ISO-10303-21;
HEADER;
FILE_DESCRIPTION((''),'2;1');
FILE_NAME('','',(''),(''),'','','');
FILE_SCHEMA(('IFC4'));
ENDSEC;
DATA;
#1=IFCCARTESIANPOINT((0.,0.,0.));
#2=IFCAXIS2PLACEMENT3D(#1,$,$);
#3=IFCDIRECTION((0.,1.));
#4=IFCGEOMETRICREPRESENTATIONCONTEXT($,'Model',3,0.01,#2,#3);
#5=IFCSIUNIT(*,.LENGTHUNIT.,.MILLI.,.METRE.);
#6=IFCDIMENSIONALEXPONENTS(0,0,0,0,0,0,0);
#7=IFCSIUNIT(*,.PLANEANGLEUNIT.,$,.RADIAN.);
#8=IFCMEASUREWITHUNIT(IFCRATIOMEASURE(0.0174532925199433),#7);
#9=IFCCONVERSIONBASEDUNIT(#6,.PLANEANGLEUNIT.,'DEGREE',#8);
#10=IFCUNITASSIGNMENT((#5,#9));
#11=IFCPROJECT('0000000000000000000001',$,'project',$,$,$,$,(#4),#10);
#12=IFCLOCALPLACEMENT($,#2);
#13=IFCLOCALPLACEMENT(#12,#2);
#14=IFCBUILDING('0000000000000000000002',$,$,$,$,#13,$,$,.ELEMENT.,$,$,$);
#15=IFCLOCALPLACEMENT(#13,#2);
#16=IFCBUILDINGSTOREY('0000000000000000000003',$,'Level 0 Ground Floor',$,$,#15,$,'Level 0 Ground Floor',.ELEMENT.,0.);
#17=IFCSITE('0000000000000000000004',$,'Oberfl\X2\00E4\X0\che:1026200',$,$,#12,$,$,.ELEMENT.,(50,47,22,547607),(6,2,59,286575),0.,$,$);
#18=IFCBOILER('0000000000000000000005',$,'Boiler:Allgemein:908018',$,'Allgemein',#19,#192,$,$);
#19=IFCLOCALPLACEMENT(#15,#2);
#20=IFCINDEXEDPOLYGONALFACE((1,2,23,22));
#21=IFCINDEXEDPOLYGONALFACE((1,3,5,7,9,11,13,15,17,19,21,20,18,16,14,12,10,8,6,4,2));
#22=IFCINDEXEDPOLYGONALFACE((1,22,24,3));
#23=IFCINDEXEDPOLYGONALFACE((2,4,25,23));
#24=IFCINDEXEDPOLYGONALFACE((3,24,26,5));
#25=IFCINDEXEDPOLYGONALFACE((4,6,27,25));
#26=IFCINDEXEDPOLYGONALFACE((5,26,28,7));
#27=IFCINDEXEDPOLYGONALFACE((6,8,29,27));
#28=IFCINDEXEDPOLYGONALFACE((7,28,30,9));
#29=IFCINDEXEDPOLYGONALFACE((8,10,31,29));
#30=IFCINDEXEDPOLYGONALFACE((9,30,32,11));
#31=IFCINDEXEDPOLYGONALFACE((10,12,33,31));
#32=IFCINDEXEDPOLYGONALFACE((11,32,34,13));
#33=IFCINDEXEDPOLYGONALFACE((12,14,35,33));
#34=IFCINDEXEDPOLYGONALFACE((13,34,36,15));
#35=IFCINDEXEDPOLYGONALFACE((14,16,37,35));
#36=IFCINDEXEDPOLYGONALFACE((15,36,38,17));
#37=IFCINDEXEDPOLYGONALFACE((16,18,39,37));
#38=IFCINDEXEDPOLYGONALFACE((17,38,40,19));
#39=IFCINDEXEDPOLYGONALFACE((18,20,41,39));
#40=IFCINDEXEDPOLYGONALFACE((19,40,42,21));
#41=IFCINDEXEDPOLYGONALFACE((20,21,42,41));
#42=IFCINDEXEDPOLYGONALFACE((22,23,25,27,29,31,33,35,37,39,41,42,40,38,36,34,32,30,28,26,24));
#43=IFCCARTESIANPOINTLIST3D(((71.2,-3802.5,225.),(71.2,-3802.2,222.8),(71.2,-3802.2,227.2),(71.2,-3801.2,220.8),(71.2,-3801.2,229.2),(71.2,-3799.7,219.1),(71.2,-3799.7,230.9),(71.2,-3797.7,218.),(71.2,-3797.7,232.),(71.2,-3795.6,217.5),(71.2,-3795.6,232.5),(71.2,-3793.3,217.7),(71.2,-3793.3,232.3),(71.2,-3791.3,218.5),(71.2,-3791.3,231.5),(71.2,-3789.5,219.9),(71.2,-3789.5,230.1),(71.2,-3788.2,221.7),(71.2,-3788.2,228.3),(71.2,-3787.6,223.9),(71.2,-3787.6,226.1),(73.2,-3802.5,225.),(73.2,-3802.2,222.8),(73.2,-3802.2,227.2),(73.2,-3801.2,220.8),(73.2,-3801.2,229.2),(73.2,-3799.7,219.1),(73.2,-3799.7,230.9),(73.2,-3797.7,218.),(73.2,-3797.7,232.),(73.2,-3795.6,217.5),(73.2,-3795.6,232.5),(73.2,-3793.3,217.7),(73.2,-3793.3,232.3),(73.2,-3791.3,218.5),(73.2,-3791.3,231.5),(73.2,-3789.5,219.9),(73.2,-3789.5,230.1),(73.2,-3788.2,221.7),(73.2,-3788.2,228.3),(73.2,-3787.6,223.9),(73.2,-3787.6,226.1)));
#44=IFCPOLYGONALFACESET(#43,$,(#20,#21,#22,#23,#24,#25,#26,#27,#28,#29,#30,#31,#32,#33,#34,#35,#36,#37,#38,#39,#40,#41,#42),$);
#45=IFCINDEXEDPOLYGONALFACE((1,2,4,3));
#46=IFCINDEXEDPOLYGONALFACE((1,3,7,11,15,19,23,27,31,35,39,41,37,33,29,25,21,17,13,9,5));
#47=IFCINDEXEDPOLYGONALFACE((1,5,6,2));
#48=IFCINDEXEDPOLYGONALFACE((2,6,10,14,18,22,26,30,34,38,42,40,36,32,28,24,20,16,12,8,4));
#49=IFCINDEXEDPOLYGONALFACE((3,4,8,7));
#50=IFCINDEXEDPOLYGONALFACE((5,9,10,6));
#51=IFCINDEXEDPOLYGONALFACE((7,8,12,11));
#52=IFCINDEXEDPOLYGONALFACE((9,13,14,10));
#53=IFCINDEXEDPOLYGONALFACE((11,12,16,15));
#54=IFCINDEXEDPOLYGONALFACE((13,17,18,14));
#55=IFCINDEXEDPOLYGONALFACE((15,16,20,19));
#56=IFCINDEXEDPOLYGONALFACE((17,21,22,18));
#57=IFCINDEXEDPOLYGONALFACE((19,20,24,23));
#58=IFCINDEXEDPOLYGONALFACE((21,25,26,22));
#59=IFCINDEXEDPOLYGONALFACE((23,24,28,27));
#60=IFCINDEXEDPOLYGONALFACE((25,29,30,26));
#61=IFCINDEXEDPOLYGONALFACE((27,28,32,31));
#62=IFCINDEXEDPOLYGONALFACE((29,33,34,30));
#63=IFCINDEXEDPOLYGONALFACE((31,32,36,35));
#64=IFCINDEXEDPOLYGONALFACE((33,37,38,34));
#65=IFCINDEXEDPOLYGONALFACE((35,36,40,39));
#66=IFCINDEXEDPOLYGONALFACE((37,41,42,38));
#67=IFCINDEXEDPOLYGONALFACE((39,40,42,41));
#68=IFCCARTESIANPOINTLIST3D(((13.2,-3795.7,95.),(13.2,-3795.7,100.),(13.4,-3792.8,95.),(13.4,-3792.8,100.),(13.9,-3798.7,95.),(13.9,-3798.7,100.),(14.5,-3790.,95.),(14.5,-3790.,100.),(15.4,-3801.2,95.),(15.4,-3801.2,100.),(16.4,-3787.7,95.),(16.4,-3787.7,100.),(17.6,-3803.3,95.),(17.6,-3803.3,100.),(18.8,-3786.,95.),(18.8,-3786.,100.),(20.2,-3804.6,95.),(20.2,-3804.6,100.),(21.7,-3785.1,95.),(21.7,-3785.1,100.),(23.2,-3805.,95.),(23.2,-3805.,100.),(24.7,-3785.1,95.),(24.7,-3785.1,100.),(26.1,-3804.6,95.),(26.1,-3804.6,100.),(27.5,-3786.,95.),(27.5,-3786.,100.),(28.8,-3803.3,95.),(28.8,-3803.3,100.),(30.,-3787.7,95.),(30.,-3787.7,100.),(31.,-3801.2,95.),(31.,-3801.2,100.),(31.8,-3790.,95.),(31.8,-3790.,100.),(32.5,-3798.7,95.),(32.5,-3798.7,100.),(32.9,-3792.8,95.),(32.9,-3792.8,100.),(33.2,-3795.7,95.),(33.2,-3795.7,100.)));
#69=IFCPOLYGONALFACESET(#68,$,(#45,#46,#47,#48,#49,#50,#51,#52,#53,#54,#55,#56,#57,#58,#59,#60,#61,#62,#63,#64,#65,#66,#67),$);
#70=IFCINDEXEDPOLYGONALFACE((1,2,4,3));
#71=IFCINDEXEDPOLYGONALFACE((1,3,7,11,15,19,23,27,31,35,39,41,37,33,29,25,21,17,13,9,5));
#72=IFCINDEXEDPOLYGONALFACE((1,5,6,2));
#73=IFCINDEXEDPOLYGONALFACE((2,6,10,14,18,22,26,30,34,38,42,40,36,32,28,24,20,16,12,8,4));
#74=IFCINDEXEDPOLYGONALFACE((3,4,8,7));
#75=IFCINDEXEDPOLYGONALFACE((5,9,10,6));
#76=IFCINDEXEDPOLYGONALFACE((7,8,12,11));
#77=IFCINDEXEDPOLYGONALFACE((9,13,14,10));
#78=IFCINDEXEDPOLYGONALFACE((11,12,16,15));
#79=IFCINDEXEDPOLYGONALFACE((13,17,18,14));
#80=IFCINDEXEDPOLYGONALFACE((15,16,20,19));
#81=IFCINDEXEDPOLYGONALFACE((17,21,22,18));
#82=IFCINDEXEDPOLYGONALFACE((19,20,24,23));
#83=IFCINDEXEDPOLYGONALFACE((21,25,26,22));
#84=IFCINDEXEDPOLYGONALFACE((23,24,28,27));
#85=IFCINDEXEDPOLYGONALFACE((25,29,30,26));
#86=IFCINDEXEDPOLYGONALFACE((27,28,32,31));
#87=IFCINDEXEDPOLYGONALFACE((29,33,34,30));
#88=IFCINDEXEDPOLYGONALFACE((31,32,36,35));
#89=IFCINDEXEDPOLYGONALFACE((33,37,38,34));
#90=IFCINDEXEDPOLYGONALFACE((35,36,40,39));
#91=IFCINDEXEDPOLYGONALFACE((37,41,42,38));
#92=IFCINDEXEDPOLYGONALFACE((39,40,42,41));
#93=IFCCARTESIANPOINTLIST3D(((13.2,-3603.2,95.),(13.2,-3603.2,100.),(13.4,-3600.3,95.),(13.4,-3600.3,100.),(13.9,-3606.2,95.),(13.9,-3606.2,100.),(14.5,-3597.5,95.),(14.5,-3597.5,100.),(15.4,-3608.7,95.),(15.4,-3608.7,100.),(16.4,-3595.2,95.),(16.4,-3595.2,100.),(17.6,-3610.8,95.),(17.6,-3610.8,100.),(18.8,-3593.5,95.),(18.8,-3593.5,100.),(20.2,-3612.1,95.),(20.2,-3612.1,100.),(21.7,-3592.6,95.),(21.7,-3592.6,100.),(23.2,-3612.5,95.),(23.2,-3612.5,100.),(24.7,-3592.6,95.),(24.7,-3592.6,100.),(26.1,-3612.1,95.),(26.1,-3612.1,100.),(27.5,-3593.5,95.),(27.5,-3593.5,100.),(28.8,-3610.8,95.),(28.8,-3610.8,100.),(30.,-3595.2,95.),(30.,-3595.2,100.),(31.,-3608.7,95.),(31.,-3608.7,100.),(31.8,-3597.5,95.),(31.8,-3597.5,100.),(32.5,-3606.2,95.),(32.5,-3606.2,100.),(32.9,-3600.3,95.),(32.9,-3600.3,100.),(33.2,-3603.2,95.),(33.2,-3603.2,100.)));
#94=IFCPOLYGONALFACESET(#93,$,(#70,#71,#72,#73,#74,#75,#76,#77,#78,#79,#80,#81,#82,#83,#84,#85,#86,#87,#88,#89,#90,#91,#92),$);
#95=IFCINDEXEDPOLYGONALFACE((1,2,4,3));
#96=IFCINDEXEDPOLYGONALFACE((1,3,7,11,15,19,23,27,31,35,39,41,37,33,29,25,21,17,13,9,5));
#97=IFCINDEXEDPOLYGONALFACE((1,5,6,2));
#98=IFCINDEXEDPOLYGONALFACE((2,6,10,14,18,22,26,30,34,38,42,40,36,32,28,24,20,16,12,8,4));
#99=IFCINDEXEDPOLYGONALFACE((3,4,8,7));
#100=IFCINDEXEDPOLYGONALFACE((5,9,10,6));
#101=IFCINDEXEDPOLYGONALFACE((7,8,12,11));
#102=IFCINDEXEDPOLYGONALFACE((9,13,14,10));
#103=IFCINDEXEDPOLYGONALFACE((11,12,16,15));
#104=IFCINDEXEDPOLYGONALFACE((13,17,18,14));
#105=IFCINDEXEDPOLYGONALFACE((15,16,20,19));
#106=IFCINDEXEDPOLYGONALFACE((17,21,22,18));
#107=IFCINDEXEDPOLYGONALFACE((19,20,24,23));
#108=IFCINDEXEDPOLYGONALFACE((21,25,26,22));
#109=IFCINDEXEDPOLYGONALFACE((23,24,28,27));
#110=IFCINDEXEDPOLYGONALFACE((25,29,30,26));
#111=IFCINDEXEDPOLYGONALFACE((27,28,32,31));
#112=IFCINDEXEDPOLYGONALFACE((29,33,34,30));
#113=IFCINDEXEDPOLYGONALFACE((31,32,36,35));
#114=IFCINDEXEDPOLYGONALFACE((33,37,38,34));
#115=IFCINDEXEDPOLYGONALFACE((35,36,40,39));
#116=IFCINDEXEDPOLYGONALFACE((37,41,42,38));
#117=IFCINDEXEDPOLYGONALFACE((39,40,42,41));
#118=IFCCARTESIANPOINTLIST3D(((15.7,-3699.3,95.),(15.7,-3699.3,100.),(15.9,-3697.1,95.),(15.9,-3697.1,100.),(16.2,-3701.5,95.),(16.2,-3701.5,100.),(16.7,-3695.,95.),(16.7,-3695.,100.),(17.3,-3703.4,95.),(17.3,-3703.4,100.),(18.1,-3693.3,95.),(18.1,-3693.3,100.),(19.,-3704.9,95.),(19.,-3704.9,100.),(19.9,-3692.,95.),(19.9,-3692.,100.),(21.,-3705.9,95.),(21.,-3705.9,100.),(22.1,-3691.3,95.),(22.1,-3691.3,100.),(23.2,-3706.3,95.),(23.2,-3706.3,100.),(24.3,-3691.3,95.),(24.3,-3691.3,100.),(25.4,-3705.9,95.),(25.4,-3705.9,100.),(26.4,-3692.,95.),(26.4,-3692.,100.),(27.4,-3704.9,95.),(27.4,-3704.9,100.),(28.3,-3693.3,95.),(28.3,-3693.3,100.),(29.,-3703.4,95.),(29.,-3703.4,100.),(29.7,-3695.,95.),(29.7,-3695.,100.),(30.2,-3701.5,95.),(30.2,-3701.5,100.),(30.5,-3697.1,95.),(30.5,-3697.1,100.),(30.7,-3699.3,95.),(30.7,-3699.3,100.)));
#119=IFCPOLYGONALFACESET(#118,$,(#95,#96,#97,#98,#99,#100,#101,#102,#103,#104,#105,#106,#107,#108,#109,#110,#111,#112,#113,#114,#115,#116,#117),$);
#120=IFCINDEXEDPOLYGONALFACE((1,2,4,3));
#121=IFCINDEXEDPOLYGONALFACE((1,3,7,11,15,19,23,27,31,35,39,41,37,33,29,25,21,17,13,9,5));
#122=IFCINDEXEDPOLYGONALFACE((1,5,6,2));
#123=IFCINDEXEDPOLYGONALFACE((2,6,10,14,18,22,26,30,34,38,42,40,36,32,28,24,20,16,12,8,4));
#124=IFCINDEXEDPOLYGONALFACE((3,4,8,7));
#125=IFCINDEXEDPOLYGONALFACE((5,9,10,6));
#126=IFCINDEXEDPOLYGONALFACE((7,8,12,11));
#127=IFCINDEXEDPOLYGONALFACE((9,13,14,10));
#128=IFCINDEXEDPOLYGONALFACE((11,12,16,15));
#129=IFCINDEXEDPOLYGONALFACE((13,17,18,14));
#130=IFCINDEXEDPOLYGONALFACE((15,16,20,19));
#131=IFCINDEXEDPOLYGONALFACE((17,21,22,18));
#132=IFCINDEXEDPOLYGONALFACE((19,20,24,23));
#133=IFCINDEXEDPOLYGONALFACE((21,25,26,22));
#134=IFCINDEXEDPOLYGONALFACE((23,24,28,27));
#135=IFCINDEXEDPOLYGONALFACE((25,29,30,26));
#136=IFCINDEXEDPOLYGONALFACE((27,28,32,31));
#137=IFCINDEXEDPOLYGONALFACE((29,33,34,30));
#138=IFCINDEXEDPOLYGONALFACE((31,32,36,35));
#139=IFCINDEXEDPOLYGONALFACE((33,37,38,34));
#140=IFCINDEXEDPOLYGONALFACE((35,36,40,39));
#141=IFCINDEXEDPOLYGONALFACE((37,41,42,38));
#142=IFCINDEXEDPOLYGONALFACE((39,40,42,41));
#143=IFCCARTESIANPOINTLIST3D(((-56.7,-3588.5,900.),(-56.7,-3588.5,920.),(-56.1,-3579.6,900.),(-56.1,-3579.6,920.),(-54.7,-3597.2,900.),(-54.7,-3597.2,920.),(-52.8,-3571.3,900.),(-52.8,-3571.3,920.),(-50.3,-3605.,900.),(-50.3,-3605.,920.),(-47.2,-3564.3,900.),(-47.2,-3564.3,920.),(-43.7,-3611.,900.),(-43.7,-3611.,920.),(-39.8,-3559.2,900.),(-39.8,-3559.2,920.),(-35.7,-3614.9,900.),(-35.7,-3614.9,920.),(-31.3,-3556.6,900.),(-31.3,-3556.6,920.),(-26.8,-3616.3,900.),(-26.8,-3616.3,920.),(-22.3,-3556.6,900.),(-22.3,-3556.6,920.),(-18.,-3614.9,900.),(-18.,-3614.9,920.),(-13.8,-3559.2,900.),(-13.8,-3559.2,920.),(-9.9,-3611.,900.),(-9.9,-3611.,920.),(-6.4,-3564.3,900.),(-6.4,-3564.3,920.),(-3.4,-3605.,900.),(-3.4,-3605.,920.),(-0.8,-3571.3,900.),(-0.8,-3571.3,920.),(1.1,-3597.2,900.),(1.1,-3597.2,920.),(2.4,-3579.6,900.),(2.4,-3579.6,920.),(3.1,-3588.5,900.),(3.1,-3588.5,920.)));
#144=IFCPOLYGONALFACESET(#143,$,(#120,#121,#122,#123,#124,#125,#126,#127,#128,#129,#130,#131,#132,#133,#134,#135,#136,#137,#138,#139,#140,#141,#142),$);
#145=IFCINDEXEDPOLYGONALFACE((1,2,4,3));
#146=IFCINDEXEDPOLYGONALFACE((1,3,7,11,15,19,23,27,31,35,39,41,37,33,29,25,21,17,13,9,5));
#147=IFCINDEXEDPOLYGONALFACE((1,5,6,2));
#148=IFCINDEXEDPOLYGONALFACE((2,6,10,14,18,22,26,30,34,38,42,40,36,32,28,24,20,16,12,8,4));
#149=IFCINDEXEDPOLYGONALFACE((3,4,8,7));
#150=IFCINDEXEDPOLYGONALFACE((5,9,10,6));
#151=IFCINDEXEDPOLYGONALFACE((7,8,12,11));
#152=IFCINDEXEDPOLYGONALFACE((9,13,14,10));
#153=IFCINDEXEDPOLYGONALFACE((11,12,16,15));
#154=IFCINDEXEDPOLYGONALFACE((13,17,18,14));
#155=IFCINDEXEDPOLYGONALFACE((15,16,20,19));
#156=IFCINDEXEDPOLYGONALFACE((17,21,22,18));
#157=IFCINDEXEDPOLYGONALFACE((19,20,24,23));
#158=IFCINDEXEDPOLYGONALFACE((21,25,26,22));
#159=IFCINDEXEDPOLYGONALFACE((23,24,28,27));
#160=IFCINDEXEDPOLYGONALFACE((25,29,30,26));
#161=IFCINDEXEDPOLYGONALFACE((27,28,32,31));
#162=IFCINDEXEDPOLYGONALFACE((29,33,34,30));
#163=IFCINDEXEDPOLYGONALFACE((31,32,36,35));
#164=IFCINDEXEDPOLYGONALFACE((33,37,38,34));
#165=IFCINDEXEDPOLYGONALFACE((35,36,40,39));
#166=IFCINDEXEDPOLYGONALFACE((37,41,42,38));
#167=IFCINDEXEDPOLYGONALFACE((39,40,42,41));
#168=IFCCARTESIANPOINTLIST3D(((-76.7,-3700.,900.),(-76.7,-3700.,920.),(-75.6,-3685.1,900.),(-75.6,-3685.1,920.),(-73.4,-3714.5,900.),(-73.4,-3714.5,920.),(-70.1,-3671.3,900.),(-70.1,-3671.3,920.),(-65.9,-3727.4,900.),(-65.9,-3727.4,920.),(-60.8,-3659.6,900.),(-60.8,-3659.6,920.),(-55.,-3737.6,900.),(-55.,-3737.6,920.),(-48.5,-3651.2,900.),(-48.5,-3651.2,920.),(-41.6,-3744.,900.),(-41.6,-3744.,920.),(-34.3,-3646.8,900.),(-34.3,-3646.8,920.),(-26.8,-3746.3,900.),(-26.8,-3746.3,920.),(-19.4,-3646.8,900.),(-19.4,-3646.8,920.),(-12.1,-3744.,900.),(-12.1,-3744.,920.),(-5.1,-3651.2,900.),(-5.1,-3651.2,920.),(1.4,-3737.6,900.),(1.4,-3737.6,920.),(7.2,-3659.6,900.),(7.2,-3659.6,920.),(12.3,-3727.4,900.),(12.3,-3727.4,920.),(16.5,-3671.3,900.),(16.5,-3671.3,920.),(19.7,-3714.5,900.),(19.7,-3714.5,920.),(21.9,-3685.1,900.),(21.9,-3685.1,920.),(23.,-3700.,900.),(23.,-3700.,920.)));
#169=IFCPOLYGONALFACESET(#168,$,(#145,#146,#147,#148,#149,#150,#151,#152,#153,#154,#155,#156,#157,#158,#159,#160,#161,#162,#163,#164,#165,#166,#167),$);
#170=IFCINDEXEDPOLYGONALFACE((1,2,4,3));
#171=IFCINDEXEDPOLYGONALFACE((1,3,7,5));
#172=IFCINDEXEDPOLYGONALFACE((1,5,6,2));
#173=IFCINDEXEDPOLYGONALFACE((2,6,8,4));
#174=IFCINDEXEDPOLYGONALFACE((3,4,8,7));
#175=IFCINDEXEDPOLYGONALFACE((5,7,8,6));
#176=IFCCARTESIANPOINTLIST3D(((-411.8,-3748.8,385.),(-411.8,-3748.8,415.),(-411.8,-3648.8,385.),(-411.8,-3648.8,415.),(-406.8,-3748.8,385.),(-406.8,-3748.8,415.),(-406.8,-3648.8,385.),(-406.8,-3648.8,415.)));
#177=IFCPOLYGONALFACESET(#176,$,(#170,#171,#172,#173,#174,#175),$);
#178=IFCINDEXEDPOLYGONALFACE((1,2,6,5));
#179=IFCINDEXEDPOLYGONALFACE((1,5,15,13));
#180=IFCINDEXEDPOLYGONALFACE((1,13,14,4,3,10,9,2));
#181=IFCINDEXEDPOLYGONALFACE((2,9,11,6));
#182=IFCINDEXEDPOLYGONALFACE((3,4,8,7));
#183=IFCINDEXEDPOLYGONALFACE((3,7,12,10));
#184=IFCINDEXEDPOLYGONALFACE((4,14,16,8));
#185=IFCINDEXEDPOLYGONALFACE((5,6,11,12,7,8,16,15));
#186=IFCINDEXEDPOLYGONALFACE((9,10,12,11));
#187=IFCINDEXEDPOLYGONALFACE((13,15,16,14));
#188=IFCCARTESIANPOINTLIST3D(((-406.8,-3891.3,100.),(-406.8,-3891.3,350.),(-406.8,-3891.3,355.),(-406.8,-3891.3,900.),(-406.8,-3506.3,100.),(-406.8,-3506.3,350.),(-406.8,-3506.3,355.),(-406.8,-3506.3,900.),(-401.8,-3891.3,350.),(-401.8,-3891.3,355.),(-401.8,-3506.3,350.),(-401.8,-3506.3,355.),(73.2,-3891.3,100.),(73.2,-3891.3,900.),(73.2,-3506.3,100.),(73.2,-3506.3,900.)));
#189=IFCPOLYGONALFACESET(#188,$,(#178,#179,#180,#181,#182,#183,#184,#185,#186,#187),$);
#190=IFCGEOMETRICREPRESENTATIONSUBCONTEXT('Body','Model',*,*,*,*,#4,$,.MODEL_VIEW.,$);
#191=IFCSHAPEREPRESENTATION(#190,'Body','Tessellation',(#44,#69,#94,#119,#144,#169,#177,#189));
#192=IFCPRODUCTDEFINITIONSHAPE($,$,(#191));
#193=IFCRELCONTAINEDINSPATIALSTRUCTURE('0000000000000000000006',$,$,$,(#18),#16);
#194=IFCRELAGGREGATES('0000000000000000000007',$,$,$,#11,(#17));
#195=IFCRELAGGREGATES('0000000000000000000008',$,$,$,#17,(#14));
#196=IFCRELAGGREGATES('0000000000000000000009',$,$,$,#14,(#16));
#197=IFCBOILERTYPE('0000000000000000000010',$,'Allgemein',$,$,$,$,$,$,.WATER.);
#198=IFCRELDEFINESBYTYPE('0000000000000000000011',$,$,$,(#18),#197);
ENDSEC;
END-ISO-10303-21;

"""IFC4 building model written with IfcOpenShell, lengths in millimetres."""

from ifc_helpers import new_model, entity, si_unit, converted_unit, direction, frame, frame_2d, origin, origin_2d_with_axis, place, context, subcontext, project, spatial, polyline, rectangle, circle, outline, extrude, source, transform, mapped, type_object, type_shapes, element, save


model = new_model("IFC4")

# Units and contexts
model_context = context("Model", 3, precision=0.01, world=origin(), true_north=direction((0.0, 1.0)))
body_context = subcontext(model_context, "Body", "Model", "MODEL_VIEW")
ifc_project = project(units=[si_unit("LENGTHUNIT", "METRE", prefix="MILLI"), converted_unit("PLANEANGLEUNIT", "DEGREE", entity("IfcRatioMeasure", 0.0174532925199433), si_unit("PLANEANGLEUNIT", "RADIAN"), dimensions=[0, 0, 0, 0, 0, 0, 0])], contexts=[model_context])

# Site, building, storey
site_placement = place(None, origin())
site = spatial("IfcSite", under=ifc_project, at=site_placement, Name="Oberfläche:1026200", CompositionType="ELEMENT", RefLatitude=(50, 47, 22, 547607), RefLongitude=(6, 2, 59, 286575), RefElevation=0.0)
building_placement = place(site_placement, origin())
building = spatial("IfcBuilding", under=site, at=building_placement, CompositionType="ELEMENT")
storey_placement = place(building_placement, origin())
storey = spatial("IfcBuildingStorey", under=building, at=storey_placement, Name="Level 0 Ground Floor", LongName="Level 0 Ground Floor", CompositionType="ELEMENT", Elevation=0.0)

# Boiler
boiler_type = type_object("IfcBoilerType", Name="Allgemein", PredefinedType="WATER")
shared_shape_1 = source(origin(), body_context, "Body", "SweptSolid", [
    extrude(circle(Radius=7.5, at=frame_2d((0.0, 0.0), x_axis=(1.0, 0.0))), frame((96.3, -2.0, 125.0), z_axis=(0.0, 1.0, 0.0), x_axis=(1.0, 0.0, 0.0)), (0.0, 0.0, 1.0), 2.0),
    extrude(circle(Radius=10.0, at=frame_2d((0.0, 0.0), x_axis=(1.0, 0.0))), frame((96.2, -50.0, -5.0)), (0.0, 0.0, 1.0), 5.0),
    extrude(circle(Radius=10.0, at=frame_2d((0.0, 0.0), x_axis=(1.0, 0.0))), frame((-96.3, -50.0, -5.0)), (0.0, 0.0, 1.0), 5.0),
    extrude(circle(Radius=7.5, at=frame_2d((0.0, 0.0), x_axis=(1.0, 0.0))), frame((0.0, -50.0, -5.0)), (0.0, 0.0, 1.0), 5.0),
    extrude(circle(Radius=30.0, at=frame_2d((0.0, 0.0), x_axis=(1.0, 0.0))), frame((-112.5, -100.0, 800.0)), (0.0, 0.0, 1.0), 20.0),
    extrude(circle(Radius=50.0, at=frame_2d((0.0, 0.0), x_axis=(1.0, 0.0))), frame((-2.5, -100.0, 800.0)), (0.0, 0.0, 1.0), 20.0),
    extrude(rectangle(XDim=5.0, YDim=100.0, at=origin_2d_with_axis()), frame((0.0, -482.5, 285.0), z_axis=(0.0, 0.0, 1.0), x_axis=(0.0, 1.0, 0.0)), (0.0, 0.0, 1.0), 30.0),
    extrude(outline(polyline([(-358.8, -473.8), (121.2, -473.8), (121.2, 71.2), (116.3, 71.2), (116.3, 76.3), (121.2, 76.3), (121.2, 326.2), (-358.8, 326.2), (-358.8, -473.8)])), frame((-192.5, -358.8, 326.2), z_axis=(1.0, 0.0, 0.0), x_axis=(0.0, -1.0, 0.0)), (0.0, 0.0, 1.0), 385.0),
])
type_shapes(boiler_type, [shared_shape_1])
boiler_placement = place(storey_placement, frame((73.2, -3698.8, 100.0), z_axis=(0.0, 0.0, 1.0), x_axis=(0.0, -1.0, 0.0)))
element("IfcBoiler", 1, at=boiler_placement, inside=storey, type_object=boiler_type, Name="Boiler:Allgemein:908018", ObjectType="Allgemein", context=body_context, shape_type="MappedRepresentation", body=[
    mapped(shared_shape_1, transform((0.0, 0.0, 0.0), scale=1.0)),
])

save(model, "model.ifc")
